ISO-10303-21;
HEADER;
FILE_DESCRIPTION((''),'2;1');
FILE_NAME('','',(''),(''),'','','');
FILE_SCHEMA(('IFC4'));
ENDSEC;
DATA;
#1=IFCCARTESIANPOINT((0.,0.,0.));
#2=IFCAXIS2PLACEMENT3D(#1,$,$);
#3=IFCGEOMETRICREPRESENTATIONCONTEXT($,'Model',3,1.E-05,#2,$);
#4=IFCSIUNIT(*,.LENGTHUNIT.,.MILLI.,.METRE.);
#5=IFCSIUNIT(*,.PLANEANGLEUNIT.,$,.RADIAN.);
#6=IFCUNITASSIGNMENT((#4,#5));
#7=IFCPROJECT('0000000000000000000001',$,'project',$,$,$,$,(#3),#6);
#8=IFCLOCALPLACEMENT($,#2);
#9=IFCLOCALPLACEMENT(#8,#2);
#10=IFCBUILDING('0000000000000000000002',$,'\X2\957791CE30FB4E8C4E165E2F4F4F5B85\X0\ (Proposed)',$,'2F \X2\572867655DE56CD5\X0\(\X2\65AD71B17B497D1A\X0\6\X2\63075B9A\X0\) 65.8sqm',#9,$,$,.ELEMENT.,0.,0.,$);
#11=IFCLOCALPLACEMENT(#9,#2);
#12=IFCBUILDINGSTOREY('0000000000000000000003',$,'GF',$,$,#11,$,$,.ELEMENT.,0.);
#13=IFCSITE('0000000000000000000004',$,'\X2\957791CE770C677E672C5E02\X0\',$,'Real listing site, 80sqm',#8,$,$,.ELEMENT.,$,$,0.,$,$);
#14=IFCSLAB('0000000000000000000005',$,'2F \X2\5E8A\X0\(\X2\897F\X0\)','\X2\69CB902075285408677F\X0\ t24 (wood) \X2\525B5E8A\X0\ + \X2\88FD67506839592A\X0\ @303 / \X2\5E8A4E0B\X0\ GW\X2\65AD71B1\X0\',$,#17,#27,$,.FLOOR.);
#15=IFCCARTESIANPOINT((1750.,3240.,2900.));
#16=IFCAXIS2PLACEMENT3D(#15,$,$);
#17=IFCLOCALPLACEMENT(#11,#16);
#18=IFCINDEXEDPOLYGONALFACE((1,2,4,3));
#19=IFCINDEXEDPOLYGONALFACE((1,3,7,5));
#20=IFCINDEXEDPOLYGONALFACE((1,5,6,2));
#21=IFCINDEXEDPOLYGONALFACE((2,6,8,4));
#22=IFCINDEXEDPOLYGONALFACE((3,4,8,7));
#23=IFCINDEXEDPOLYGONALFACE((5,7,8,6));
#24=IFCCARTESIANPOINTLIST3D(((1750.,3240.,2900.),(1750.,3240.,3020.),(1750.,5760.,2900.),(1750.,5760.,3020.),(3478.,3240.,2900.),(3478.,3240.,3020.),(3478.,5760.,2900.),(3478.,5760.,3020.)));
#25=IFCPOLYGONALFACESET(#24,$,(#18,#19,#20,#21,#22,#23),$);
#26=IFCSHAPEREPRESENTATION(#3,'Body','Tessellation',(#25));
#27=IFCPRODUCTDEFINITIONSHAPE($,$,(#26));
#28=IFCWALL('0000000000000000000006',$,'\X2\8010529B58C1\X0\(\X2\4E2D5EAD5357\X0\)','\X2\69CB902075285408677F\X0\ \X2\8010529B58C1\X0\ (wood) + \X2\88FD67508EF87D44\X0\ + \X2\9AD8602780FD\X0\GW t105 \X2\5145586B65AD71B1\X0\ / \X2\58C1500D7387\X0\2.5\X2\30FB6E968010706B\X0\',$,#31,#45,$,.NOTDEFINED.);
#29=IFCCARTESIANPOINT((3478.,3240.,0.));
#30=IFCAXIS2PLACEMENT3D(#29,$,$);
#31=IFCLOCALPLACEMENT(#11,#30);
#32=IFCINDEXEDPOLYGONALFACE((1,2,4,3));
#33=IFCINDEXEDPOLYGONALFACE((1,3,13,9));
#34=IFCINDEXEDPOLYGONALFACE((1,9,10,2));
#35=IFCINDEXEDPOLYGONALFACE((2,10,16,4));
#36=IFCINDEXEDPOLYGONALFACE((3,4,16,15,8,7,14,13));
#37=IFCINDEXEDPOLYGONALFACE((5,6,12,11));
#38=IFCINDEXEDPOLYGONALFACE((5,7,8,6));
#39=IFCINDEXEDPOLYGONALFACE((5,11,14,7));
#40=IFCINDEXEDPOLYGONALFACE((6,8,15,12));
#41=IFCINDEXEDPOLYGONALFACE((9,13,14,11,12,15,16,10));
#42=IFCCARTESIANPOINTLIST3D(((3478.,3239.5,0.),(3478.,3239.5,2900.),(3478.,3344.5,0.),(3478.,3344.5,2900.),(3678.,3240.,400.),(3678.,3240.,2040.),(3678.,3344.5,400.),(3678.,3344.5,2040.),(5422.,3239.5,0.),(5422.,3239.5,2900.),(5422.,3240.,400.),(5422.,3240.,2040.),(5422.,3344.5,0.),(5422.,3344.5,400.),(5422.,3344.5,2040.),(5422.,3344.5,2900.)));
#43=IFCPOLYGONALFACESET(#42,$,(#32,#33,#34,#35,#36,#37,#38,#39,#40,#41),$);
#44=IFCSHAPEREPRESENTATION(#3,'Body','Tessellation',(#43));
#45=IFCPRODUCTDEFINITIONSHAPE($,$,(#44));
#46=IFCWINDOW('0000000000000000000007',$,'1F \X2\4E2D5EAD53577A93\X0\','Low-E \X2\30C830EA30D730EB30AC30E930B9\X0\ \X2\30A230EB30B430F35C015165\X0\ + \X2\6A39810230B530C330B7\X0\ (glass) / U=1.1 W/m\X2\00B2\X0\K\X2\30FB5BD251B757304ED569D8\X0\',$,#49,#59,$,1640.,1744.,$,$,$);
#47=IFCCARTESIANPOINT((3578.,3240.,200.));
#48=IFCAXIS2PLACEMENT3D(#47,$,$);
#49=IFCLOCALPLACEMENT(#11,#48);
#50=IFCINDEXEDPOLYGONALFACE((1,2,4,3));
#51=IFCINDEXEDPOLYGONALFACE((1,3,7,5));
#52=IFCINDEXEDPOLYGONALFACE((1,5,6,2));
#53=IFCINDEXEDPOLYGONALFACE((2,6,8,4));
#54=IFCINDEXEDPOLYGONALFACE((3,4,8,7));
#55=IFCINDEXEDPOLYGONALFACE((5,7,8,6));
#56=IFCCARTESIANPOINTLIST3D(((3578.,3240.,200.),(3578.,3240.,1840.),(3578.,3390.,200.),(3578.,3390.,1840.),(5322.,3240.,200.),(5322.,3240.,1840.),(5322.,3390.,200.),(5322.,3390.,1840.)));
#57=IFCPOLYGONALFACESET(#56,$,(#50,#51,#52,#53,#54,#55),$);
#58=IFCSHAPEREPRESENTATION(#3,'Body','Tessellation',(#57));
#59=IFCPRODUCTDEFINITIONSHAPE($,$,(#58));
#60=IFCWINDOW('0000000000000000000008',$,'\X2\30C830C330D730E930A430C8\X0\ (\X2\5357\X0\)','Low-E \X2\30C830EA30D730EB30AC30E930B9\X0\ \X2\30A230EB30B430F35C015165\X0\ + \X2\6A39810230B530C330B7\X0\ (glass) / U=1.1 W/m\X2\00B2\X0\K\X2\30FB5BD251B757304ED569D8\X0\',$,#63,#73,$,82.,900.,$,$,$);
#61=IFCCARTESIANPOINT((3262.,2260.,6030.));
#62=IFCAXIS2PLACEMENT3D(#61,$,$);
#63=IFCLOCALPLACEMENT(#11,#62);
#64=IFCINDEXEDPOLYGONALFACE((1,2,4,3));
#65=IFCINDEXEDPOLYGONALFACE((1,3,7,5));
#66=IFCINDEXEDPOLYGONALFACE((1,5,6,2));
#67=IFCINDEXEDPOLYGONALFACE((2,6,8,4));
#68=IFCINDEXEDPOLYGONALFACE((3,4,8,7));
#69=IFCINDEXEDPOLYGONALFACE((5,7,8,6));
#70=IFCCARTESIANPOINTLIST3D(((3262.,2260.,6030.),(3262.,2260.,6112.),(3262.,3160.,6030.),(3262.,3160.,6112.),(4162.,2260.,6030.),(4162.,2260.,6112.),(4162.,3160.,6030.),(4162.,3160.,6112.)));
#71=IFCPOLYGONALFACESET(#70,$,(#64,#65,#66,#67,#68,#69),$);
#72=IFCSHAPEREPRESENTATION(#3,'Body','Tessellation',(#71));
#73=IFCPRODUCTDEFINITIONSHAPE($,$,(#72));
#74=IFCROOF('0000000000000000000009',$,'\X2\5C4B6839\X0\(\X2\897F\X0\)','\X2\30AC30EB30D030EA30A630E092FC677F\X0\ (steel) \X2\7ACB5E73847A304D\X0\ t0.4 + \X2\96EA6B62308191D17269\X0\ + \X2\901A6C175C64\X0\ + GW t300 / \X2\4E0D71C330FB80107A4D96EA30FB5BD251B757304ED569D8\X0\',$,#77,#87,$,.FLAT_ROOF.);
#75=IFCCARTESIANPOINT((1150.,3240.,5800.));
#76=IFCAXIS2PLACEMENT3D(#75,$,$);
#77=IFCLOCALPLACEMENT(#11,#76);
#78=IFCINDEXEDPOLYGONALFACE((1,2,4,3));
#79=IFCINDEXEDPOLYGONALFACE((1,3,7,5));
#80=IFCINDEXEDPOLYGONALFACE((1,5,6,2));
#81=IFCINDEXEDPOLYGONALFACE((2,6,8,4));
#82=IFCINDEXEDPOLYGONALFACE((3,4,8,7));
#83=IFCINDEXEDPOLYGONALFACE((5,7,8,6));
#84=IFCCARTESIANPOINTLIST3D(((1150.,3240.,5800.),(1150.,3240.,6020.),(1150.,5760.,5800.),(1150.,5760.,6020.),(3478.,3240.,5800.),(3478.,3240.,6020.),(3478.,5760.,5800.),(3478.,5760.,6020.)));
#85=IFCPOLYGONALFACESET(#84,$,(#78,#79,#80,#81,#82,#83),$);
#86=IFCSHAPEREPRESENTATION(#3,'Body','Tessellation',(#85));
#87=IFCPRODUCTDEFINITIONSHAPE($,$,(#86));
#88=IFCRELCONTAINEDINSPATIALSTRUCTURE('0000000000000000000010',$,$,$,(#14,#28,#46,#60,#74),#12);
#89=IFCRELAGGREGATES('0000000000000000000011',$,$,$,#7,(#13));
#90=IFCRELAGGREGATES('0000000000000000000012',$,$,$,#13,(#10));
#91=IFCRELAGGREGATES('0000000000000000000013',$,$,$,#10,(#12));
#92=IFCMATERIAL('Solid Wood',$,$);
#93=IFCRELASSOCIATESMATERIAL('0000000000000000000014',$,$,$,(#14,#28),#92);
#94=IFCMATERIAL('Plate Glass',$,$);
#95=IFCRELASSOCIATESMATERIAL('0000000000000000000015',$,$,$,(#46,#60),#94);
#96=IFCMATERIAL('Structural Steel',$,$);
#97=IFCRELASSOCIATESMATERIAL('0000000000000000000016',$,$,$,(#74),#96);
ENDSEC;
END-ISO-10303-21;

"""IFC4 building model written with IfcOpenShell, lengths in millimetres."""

from ifc_helpers import new_model, si_unit, frame, frame_2d, origin, place, context, project, spatial, rectangle, extrude, material, element, fill, save


model = new_model("IFC4")

# Units and contexts
model_context = context("Model", 3, precision=1e-05, world=origin())
ifc_project = project(units=[si_unit("LENGTHUNIT", "METRE", prefix="MILLI"), si_unit("PLANEANGLEUNIT", "RADIAN")], contexts=[model_context])

# Site, building, storey
site_placement = place(None, origin())
site = spatial("IfcSite", under=ifc_project, at=site_placement, Name="長野県松本市", ObjectType="Real listing site, 80sqm", CompositionType="ELEMENT", RefElevation=0.0)
building_placement = place(site_placement, origin())
building = spatial("IfcBuilding", under=site, at=building_placement, Name="長野・二世帯住宅 (Proposed)", ObjectType="2F 在来工法(断熱等級6指定) 65.8sqm", CompositionType="ELEMENT", ElevationOfRefHeight=0.0, ElevationOfTerrain=0.0)
storey_placement = place(building_placement, origin())
storey = spatial("IfcBuildingStorey", under=building, at=storey_placement, Name="GF", CompositionType="ELEMENT", Elevation=0.0)

# Shared definitions
ifc_material_1 = material(Name="Solid Wood")

# Slab
slab_1_placement = place(storey_placement, frame((1750.0, 3240.0, 2900.0)))
element("IfcSlab", 1, at=slab_1_placement, inside=storey, material=ifc_material_1, Name="2F 床(西)", Description="構造用合板 t24 (wood) 剛床 + 製材根太 @303 / 床下 GW断熱", PredefinedType="FLOOR", context=model_context, shape_type="SweptSolid", body=[
    extrude(rectangle(XDim=1728.0, YDim=2520.0, at=frame_2d((864.0, 1260.0))), frame((1750.0, 3240.0, 2900.0)), (0.0, 0.0, 1.0), 120.0),
])

# Wall, opening, window
wall_placement = place(storey_placement, frame((3478.0, 3240.0, 0.0)))
wall = element("IfcWall", 2, at=wall_placement, inside=storey, material=ifc_material_1, Name="耐力壁(中庭南)", Description="構造用合板 耐力壁 (wood) + 製材軸組 + 高性能GW t105 充填断熱 / 壁倍率2.5・準耐火", PredefinedType="NOTDEFINED", context=model_context, shape_type="SweptSolid", body=[
    extrude(rectangle(XDim=1944.0, YDim=105.0, at=frame_2d((972.0, 52.0))), frame((3478.0, 3240.0, 0.0)), (0.0, 0.0, 1.0), 2900.0),
])
opening_placement = place(storey_placement, frame((3578.0, 3240.0, 200.0)))
opening = element("IfcOpeningElement", 3, at=opening_placement, cuts=wall, PredefinedType="NOTDEFINED", context=model_context, shape_type="SweptSolid", body=[
    extrude(rectangle(XDim=1744.0, YDim=150.0, at=frame_2d((872.0, 75.0))), frame((3578.0, 3240.0, 200.0)), (0.0, 0.0, 1.0), 1640.0),
])
ifc_material_2 = material(Name="Plate Glass")
window_1_placement = place(storey_placement, frame((3578.0, 3240.0, 200.0)))
window_1 = element("IfcWindow", 4, at=window_1_placement, inside=storey, material=ifc_material_2, Name="1F 中庭南窓", Description="Low-E トリプルガラス アルゴン封入 + 樹脂サッシ (glass) / U=1.1 W/m²K・寒冷地仕様", OverallHeight=1640.0, OverallWidth=1744.0, context=model_context, shape_type="SweptSolid", body=[
    extrude(rectangle(XDim=1744.0, YDim=150.0, at=frame_2d((872.0, 75.0))), frame((3578.0, 3240.0, 200.0)), (0.0, 0.0, 1.0), 1640.0),
])
fill(opening, window_1)

# Window
window_2_placement = place(storey_placement, frame((3262.0, 2260.0, 6030.0)))
element("IfcWindow", 5, at=window_2_placement, inside=storey, material=ifc_material_2, Name="トップライト (南)", Description="Low-E トリプルガラス アルゴン封入 + 樹脂サッシ (glass) / U=1.1 W/m²K・寒冷地仕様", OverallHeight=82.0, OverallWidth=900.0, context=model_context, shape_type="SweptSolid", body=[
    extrude(rectangle(XDim=900.0, YDim=900.0, at=frame_2d((450.0, 450.0))), frame((3262.0, 2260.0, 6030.0)), (0.0, 0.0, 1.0), 82.0),
])

# Roof
ifc_material_3 = material(Name="Structural Steel")
for number, where, name in (
    (6, (1150.0, 3240.0, 5800.0), "屋根(西)"),
):
    element("IfcRoof", number, at=place(storey_placement, frame(where)), inside=storey, material=ifc_material_3, Name=name, Description="ガルバリウム鋼板 (steel) 立平葺き t0.4 + 雪止め金物 + 通気層 + GW t300 / 不燃・耐積雪・寒冷地仕様", PredefinedType="FLAT_ROOF", context=model_context, shape_type="SweptSolid", body=[
        extrude(rectangle(XDim=2328.0, YDim=2520.0, at=frame_2d((1164.0, 1260.0))), frame((1150.0, 3240.0, 5800.0)), (0.0, 0.0, 1.0), 220.0),
    ])

save(model, "model.ifc")
